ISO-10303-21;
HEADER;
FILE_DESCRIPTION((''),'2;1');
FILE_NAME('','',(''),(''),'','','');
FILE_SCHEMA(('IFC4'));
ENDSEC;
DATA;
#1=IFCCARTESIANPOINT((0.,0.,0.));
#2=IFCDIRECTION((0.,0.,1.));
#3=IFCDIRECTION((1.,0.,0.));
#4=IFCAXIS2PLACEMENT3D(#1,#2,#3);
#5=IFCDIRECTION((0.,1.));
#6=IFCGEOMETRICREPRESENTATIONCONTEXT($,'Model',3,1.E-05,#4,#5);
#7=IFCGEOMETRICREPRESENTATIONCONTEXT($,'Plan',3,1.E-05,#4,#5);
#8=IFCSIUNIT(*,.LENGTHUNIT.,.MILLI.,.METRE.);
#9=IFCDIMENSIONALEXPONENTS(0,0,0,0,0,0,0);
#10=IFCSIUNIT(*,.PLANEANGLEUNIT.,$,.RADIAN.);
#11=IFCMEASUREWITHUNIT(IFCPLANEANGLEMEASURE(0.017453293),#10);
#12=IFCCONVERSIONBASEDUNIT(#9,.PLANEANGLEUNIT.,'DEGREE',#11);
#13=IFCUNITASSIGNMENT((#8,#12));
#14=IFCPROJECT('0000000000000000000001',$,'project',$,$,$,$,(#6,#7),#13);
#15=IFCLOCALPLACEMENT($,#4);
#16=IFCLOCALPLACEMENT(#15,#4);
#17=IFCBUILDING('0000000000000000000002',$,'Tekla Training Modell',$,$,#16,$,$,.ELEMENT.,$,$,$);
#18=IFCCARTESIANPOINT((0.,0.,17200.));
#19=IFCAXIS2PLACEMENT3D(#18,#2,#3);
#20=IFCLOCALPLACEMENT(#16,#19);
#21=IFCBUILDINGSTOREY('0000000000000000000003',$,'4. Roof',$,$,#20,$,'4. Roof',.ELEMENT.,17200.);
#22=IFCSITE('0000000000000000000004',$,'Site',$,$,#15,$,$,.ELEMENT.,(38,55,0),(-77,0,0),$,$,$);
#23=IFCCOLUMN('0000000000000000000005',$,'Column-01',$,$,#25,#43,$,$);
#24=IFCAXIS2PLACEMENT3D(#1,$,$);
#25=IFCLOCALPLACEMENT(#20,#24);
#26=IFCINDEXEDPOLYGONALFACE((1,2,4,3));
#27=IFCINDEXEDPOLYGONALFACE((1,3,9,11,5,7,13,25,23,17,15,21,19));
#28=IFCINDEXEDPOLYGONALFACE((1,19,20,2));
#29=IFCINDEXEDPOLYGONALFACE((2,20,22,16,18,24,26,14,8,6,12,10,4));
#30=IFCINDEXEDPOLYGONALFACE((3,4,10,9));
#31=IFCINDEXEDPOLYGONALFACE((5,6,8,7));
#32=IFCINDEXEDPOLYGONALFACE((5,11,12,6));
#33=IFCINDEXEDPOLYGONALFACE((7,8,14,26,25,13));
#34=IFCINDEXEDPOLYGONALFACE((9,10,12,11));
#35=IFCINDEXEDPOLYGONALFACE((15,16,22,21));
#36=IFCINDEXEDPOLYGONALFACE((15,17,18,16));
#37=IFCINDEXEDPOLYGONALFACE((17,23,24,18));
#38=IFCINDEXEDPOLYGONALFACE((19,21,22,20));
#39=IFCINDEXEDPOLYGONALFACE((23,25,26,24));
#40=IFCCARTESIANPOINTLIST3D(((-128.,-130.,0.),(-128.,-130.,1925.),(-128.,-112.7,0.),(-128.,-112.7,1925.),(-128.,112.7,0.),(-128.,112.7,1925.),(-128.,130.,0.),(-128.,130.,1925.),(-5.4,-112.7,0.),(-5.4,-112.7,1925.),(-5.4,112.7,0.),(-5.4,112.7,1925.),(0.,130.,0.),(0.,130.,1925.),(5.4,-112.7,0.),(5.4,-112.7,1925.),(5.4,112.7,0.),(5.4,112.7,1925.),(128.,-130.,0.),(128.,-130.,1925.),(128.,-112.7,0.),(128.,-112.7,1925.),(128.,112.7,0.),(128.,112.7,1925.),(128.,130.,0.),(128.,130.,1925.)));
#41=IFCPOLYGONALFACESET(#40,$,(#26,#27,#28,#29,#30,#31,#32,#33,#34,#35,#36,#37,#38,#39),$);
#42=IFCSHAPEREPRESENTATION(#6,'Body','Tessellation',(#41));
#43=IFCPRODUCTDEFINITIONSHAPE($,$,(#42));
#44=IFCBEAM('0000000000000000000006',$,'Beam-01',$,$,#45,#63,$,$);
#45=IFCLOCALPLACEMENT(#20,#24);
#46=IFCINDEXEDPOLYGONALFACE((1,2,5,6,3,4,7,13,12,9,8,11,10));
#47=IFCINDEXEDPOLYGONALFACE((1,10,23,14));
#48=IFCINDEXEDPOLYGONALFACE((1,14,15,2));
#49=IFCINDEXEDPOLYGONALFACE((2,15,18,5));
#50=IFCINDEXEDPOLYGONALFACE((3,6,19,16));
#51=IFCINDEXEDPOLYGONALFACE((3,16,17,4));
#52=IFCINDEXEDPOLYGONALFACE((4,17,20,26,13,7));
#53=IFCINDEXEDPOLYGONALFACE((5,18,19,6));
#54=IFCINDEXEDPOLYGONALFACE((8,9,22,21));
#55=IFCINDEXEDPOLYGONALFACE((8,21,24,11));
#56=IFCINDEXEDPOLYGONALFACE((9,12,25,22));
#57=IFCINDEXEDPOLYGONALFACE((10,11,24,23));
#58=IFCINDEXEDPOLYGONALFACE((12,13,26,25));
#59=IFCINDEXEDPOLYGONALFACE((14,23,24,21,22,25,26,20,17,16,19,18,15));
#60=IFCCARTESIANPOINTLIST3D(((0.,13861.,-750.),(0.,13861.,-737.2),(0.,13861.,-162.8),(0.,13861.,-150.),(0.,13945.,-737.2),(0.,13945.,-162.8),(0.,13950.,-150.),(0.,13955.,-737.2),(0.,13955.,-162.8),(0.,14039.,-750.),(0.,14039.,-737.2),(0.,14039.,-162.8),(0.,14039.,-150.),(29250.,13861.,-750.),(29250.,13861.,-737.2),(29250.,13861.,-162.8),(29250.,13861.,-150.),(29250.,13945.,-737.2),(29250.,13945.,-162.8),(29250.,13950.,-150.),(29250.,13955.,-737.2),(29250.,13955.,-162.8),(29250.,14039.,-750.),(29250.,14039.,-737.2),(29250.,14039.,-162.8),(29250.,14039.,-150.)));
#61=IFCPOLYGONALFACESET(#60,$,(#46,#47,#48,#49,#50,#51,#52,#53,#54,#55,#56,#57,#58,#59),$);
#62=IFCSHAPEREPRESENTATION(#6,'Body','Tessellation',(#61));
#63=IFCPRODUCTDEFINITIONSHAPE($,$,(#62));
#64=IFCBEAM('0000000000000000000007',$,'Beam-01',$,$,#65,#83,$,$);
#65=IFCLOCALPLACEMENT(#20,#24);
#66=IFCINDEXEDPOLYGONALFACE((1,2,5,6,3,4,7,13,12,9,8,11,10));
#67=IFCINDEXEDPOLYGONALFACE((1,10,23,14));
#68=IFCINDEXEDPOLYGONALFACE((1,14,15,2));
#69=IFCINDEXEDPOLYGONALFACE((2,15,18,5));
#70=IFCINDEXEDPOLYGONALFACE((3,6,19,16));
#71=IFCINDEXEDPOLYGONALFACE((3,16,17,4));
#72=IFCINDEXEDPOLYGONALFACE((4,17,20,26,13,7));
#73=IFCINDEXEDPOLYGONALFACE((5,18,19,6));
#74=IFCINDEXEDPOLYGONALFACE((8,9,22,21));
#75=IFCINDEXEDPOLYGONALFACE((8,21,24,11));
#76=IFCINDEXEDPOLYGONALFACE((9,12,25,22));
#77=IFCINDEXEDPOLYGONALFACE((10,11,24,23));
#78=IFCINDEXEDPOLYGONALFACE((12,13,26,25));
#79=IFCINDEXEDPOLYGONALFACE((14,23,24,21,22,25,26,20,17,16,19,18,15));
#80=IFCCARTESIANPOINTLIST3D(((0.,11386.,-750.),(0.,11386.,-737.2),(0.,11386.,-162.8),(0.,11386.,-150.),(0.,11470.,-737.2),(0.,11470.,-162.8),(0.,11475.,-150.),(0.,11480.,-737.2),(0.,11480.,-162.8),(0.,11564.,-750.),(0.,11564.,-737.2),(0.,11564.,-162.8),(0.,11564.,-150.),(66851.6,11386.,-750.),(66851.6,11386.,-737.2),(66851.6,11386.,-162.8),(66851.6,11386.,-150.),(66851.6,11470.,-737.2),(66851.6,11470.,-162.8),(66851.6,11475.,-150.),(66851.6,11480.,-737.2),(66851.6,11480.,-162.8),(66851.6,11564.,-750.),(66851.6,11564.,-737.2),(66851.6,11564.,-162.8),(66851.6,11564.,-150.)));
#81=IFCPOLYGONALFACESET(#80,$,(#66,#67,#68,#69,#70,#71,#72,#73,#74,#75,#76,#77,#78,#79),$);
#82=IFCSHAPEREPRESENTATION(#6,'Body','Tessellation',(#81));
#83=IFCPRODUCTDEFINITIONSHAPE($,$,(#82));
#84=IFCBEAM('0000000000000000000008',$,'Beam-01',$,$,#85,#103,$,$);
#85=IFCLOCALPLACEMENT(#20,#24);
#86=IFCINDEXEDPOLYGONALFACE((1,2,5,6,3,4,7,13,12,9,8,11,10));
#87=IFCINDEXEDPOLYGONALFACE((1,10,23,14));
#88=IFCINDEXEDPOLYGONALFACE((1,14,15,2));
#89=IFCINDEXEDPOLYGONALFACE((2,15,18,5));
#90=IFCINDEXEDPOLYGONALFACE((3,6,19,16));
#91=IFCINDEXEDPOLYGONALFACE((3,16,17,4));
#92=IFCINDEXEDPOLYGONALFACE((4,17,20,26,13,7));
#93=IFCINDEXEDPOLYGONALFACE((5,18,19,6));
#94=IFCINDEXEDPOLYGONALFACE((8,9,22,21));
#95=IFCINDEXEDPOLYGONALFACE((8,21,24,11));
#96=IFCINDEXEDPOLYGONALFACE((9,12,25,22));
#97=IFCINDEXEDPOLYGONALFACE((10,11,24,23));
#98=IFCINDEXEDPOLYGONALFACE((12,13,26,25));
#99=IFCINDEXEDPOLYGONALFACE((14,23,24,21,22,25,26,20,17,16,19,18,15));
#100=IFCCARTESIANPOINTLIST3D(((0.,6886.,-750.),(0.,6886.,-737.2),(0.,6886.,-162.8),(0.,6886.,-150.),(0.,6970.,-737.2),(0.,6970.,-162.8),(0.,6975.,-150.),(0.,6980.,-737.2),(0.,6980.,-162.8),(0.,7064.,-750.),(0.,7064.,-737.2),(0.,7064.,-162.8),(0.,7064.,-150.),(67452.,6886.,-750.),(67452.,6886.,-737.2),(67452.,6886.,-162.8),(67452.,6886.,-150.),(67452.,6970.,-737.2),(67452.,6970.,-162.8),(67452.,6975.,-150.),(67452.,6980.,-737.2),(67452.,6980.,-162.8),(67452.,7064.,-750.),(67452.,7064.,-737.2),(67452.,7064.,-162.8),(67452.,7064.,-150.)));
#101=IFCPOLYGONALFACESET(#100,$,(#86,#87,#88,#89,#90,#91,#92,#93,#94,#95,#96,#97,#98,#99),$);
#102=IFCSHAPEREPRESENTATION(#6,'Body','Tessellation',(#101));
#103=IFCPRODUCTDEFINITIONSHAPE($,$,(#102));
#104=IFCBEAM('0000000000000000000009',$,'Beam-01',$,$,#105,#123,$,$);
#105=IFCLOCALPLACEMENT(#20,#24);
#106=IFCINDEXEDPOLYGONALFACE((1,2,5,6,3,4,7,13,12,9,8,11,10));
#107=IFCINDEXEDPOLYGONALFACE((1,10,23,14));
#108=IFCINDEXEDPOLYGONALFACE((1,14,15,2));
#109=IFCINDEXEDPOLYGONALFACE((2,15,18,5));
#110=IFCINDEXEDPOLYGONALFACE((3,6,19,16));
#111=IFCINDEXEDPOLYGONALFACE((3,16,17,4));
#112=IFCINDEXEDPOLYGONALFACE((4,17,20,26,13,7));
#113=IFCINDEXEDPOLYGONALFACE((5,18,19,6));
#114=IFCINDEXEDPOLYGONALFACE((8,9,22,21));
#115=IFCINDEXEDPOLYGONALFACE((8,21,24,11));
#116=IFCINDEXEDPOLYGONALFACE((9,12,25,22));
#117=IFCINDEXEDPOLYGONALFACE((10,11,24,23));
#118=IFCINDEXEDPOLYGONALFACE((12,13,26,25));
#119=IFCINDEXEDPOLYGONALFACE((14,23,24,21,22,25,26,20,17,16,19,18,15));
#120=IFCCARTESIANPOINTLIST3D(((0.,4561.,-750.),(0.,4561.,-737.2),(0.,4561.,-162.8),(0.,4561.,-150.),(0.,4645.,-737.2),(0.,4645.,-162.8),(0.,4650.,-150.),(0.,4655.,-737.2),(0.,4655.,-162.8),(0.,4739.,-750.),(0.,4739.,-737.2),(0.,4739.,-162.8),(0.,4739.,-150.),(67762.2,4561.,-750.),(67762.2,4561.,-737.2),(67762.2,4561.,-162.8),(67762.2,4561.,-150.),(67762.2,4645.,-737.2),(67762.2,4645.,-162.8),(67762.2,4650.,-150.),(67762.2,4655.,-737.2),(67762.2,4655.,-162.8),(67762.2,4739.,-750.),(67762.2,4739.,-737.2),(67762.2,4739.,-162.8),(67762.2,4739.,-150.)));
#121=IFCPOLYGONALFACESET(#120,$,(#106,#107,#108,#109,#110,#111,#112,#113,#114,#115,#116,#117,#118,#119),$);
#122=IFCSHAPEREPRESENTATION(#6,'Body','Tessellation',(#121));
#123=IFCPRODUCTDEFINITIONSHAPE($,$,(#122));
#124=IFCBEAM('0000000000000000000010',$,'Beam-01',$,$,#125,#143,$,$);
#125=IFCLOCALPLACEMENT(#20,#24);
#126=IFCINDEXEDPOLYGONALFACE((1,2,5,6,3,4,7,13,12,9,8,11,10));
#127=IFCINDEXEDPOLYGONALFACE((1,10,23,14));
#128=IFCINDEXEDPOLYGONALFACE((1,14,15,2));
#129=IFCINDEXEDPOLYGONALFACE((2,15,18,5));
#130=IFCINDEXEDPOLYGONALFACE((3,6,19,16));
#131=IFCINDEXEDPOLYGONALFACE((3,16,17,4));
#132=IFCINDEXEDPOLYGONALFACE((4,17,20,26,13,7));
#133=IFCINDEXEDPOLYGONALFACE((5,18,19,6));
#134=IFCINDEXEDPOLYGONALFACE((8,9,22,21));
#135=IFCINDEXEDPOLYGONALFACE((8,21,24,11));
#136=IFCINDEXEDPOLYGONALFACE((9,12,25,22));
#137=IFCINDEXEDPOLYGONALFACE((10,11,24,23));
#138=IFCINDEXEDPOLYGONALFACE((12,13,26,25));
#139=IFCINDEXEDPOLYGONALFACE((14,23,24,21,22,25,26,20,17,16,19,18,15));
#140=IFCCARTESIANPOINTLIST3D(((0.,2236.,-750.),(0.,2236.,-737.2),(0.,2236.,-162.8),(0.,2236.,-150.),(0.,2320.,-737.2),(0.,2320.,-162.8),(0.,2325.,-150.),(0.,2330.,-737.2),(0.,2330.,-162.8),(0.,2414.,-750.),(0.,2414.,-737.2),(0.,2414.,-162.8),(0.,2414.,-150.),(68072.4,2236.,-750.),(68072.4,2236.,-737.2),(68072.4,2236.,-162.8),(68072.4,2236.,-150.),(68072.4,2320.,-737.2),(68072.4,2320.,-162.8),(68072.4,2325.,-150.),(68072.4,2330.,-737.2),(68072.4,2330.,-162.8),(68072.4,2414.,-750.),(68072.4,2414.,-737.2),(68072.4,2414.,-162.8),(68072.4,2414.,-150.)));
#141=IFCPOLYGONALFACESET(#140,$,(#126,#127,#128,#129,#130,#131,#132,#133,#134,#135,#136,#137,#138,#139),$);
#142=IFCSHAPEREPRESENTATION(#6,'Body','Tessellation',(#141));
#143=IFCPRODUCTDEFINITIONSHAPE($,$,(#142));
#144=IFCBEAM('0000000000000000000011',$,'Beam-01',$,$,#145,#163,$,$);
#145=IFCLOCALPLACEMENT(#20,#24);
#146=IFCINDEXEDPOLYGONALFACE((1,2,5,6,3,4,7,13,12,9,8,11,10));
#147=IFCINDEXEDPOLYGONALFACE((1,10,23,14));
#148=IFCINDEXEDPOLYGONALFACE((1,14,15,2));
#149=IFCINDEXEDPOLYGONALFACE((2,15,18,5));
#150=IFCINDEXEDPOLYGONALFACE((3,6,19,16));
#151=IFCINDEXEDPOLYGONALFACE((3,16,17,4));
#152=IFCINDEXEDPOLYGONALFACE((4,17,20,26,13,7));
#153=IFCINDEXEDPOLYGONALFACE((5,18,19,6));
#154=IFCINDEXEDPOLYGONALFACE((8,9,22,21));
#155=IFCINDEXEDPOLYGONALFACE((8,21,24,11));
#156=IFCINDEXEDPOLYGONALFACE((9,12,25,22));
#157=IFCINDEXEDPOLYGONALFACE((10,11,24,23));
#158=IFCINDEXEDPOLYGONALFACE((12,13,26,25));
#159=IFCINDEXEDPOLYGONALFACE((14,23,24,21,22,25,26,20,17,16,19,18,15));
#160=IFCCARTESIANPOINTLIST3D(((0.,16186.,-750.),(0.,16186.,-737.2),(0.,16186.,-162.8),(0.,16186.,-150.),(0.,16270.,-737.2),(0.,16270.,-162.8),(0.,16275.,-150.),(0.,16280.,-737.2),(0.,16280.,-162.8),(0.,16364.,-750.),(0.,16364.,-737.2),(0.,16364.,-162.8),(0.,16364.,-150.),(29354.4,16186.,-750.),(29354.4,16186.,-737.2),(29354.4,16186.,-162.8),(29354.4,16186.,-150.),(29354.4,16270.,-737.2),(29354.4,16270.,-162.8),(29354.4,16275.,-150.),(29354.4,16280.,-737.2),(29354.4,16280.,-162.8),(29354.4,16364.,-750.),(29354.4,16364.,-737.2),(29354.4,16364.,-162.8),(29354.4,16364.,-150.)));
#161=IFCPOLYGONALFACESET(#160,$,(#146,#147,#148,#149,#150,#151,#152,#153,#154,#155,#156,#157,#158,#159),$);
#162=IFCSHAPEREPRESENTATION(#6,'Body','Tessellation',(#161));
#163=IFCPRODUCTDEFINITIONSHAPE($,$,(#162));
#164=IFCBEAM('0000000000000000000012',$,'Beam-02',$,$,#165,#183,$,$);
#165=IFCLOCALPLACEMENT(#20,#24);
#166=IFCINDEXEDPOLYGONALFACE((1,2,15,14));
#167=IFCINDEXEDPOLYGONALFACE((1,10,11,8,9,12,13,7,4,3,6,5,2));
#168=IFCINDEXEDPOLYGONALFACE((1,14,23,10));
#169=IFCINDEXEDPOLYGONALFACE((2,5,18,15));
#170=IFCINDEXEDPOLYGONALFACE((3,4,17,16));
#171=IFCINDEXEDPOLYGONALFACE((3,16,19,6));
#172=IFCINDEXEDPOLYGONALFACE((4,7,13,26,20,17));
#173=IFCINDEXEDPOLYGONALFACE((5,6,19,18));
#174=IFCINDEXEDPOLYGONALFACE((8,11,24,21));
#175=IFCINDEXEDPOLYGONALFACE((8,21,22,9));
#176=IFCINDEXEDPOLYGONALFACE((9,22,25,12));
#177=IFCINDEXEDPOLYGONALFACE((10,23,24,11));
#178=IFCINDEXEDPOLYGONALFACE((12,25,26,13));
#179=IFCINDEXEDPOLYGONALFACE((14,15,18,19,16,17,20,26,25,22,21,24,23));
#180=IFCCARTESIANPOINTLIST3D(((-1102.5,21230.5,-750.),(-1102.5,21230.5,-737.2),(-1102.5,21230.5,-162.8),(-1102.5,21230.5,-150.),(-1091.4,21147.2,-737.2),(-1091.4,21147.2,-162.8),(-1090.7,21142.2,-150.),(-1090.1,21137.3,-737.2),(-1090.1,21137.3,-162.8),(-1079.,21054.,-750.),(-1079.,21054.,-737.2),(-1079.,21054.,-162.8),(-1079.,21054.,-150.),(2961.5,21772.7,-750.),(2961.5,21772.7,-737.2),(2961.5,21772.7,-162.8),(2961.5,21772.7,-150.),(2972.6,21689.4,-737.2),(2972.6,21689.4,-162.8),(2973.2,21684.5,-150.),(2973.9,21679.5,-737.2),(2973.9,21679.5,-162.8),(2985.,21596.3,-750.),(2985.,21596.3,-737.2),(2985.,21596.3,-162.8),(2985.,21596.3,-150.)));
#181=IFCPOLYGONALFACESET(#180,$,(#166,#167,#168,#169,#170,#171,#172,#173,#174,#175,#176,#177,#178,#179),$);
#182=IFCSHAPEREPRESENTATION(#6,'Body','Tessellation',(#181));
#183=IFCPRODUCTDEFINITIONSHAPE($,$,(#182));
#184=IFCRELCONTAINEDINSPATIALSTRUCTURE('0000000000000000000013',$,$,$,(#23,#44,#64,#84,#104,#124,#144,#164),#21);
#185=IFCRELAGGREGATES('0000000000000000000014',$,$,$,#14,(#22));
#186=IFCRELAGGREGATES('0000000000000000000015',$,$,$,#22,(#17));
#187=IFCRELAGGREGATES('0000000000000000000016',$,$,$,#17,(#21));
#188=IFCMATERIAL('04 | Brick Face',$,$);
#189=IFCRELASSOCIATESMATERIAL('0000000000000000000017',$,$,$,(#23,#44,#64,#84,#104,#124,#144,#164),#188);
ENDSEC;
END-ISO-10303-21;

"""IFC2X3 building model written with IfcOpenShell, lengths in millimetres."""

from ifc_helpers import new_model, entity, si_unit, converted_unit, direction, frame, origin_with_axes, place, context, project, spatial, polyline, outline, extrude, material, element, save


model = new_model("IFC2X3")

# Units and contexts
model_context = context("Model", 3, precision=1e-05, world=origin_with_axes(), true_north=direction((0.0, 1.0)))
plan_context = context("Plan", 3, precision=1e-05, world=origin_with_axes(), true_north=direction((0.0, 1.0)))
ifc_project = project(units=[si_unit("LENGTHUNIT", "METRE", prefix="MILLI"), converted_unit("PLANEANGLEUNIT", "DEGREE", entity("IfcPlaneAngleMeasure", 0.017453293), si_unit("PLANEANGLEUNIT", "RADIAN"), dimensions=[0, 0, 0, 0, 0, 0, 0])], contexts=[model_context, plan_context])

# Site, building, storey
site_placement = place(None, origin_with_axes())
site = spatial("IfcSite", under=ifc_project, at=site_placement, Name="Site", CompositionType="ELEMENT", RefLatitude=(38, 55, 0), RefLongitude=(-77, 0, 0))
building_placement = place(site_placement, origin_with_axes())
building = spatial("IfcBuilding", under=site, at=building_placement, Name="Tekla Training Modell", CompositionType="ELEMENT")
storey_placement = place(building_placement, frame((0.0, 0.0, 17200.0), z_axis=(0.0, 0.0, 1.0), x_axis=(1.0, 0.0, 0.0)))
storey = spatial("IfcBuildingStorey", under=building, at=storey_placement, Name="4. Roof", LongName="4. Roof", CompositionType="ELEMENT", Elevation=17200.0)

# Column
ifc_material_1 = material(Name="04 | Brick Face")
column_placement = place(storey_placement, origin_with_axes())
element("IfcColumn", 1, at=column_placement, inside=storey, material=ifc_material_1, Name="Column-01", context=model_context, shape_type="SweptSolid", body=[
    extrude(outline(polyline([(0.0, 130.0), (-128.0, 130.0), (-128.0, 112.7), (-5.3, 112.7), (-5.3, -112.7), (-128.0, -112.7), (-128.0, -130.0), (128.0, -130.0), (128.0, -112.7), (5.3, -112.7), (5.3, 112.7), (128.0, 112.7), (128.0, 130.0), (0.0, 130.0)])), origin_with_axes(), (0.0, 0.0, 1.0), 1925.0),
])

# Beams
beam_1_placement = place(storey_placement, frame((0.0, 13950.0, -450.0), z_axis=(0.0, 0.0, 1.0), x_axis=(0.0, -1.0, 0.0)))
element("IfcBeam", 2, at=beam_1_placement, inside=storey, material=ifc_material_1, Name="Beam-01", context=model_context, shape_type="SweptSolid", body=[
    extrude(outline(polyline([(0.0, 300.0), (-89.0, 300.0), (-89.0, 287.2), (-5.0, 287.2), (-5.0, -287.2), (-89.0, -287.2), (-89.0, -300.0), (89.0, -300.0), (89.0, -287.2), (5.0, -287.2), (5.0, 287.2), (89.0, 287.2), (89.0, 300.0), (0.0, 300.0)])), frame((0.0, 29250.0, 0.0), z_axis=(0.0, -1.0, 0.0), x_axis=(1.0, 0.0, 0.0)), (0.0, 0.0, 1.0), 29250.0),
])
beam_2_placement = place(storey_placement, frame((0.0, 11475.0, -450.0), z_axis=(0.0, 0.0, 1.0), x_axis=(0.0, -1.0, 0.0)))
element("IfcBeam", 3, at=beam_2_placement, inside=storey, material=ifc_material_1, Name="Beam-01", context=model_context, shape_type="SweptSolid", body=[
    extrude(outline(polyline([(0.0, 300.0), (-89.0, 300.0), (-89.0, 287.2), (-5.0, 287.2), (-5.0, -287.2), (-89.0, -287.2), (-89.0, -300.0), (89.0, -300.0), (89.0, -287.2), (5.0, -287.2), (5.0, 287.2), (89.0, 287.2), (89.0, 300.0), (0.0, 300.0)])), frame((0.0, 66851.6, 0.0), z_axis=(0.0, -1.0, 0.0), x_axis=(1.0, 0.0, 0.0)), (0.0, 0.0, 1.0), 66851.6),
])
beam_3_placement = place(storey_placement, frame((0.0, 6975.0, -450.0), z_axis=(0.0, 0.0, 1.0), x_axis=(0.0, -1.0, 0.0)))
element("IfcBeam", 4, at=beam_3_placement, inside=storey, material=ifc_material_1, Name="Beam-01", context=model_context, shape_type="SweptSolid", body=[
    extrude(outline(polyline([(0.0, 300.0), (-89.0, 300.0), (-89.0, 287.2), (-5.0, 287.2), (-5.0, -287.2), (-89.0, -287.2), (-89.0, -300.0), (89.0, -300.0), (89.0, -287.2), (5.0, -287.2), (5.0, 287.2), (89.0, 287.2), (89.0, 300.0), (0.0, 300.0)])), frame((0.0, 67452.0, 0.0), z_axis=(0.0, -1.0, 0.0), x_axis=(1.0, 0.0, 0.0)), (0.0, 0.0, 1.0), 67452.0),
])
beam_4_placement = place(storey_placement, frame((0.0, 4650.0, -450.0), z_axis=(0.0, 0.0, 1.0), x_axis=(0.0, -1.0, 0.0)))
element("IfcBeam", 5, at=beam_4_placement, inside=storey, material=ifc_material_1, Name="Beam-01", context=model_context, shape_type="SweptSolid", body=[
    extrude(outline(polyline([(0.0, 300.0), (-89.0, 300.0), (-89.0, 287.2), (-5.0, 287.2), (-5.0, -287.2), (-89.0, -287.2), (-89.0, -300.0), (89.0, -300.0), (89.0, -287.2), (5.0, -287.2), (5.0, 287.2), (89.0, 287.2), (89.0, 300.0), (0.0, 300.0)])), frame((0.0, 67762.2, 0.0), z_axis=(0.0, -1.0, 0.0), x_axis=(1.0, 0.0, 0.0)), (0.0, 0.0, 1.0), 67762.2),
])
beam_5_placement = place(storey_placement, frame((0.0, 2325.0, -450.0), z_axis=(0.0, 0.0, 1.0), x_axis=(0.0, -1.0, 0.0)))
element("IfcBeam", 6, at=beam_5_placement, inside=storey, material=ifc_material_1, Name="Beam-01", context=model_context, shape_type="SweptSolid", body=[
    extrude(outline(polyline([(0.0, 300.0), (-89.0, 300.0), (-89.0, 287.2), (-5.0, 287.2), (-5.0, -287.2), (-89.0, -287.2), (-89.0, -300.0), (89.0, -300.0), (89.0, -287.2), (5.0, -287.2), (5.0, 287.2), (89.0, 287.2), (89.0, 300.0), (0.0, 300.0)])), frame((0.0, 68072.4, 0.0), z_axis=(0.0, -1.0, 0.0), x_axis=(1.0, 0.0, 0.0)), (0.0, 0.0, 1.0), 68072.4),
])
beam_6_placement = place(storey_placement, frame((0.0, 16275.0, -450.0), z_axis=(0.0, 0.0, 1.0), x_axis=(0.0, -1.0, 0.0)))
element("IfcBeam", 7, at=beam_6_placement, inside=storey, material=ifc_material_1, Name="Beam-01", context=model_context, shape_type="SweptSolid", body=[
    extrude(outline(polyline([(0.0, 300.0), (-89.0, 300.0), (-89.0, 287.2), (-5.0, 287.2), (-5.0, -287.2), (-89.0, -287.2), (-89.0, -300.0), (89.0, -300.0), (89.0, -287.2), (5.0, -287.2), (5.0, 287.2), (89.0, 287.2), (89.0, 300.0), (0.0, 300.0)])), frame((0.0, 29354.4, 0.0), z_axis=(0.0, -1.0, 0.0), x_axis=(1.0, 0.0, 0.0)), (0.0, 0.0, 1.0), 29354.4),
])
for number, where, z_axis, x_axis, name in (
    (8, (-1090.7, 21142.2, -450.0), (0.0, 0.0, 1.0), (0.132256, -0.991216, 0.0), "Beam-02"),
):
    element("IfcBeam", number, at=place(storey_placement, frame(where, z_axis=z_axis, x_axis=x_axis)), inside=storey, material=ifc_material_1, Name=name, context=model_context, shape_type="SweptSolid", body=[
        extrude(outline(polyline([(0.0, 300.0), (-89.0, 300.0), (-89.0, 287.2), (-5.0, 287.2), (-5.0, -287.2), (-89.0, -287.2), (-89.0, -300.0), (89.0, -300.0), (89.0, -287.2), (5.0, -287.2), (5.0, 287.2), (89.0, 287.2), (89.0, 300.0), (0.0, 300.0)])), frame((0.0, 4100.0, 0.0), z_axis=(0.0, -1.0, 0.0), x_axis=(1.0, 0.0, 0.0)), (0.0, 0.0, 1.0), 4100.0),
    ])

save(model, "model.ifc")
